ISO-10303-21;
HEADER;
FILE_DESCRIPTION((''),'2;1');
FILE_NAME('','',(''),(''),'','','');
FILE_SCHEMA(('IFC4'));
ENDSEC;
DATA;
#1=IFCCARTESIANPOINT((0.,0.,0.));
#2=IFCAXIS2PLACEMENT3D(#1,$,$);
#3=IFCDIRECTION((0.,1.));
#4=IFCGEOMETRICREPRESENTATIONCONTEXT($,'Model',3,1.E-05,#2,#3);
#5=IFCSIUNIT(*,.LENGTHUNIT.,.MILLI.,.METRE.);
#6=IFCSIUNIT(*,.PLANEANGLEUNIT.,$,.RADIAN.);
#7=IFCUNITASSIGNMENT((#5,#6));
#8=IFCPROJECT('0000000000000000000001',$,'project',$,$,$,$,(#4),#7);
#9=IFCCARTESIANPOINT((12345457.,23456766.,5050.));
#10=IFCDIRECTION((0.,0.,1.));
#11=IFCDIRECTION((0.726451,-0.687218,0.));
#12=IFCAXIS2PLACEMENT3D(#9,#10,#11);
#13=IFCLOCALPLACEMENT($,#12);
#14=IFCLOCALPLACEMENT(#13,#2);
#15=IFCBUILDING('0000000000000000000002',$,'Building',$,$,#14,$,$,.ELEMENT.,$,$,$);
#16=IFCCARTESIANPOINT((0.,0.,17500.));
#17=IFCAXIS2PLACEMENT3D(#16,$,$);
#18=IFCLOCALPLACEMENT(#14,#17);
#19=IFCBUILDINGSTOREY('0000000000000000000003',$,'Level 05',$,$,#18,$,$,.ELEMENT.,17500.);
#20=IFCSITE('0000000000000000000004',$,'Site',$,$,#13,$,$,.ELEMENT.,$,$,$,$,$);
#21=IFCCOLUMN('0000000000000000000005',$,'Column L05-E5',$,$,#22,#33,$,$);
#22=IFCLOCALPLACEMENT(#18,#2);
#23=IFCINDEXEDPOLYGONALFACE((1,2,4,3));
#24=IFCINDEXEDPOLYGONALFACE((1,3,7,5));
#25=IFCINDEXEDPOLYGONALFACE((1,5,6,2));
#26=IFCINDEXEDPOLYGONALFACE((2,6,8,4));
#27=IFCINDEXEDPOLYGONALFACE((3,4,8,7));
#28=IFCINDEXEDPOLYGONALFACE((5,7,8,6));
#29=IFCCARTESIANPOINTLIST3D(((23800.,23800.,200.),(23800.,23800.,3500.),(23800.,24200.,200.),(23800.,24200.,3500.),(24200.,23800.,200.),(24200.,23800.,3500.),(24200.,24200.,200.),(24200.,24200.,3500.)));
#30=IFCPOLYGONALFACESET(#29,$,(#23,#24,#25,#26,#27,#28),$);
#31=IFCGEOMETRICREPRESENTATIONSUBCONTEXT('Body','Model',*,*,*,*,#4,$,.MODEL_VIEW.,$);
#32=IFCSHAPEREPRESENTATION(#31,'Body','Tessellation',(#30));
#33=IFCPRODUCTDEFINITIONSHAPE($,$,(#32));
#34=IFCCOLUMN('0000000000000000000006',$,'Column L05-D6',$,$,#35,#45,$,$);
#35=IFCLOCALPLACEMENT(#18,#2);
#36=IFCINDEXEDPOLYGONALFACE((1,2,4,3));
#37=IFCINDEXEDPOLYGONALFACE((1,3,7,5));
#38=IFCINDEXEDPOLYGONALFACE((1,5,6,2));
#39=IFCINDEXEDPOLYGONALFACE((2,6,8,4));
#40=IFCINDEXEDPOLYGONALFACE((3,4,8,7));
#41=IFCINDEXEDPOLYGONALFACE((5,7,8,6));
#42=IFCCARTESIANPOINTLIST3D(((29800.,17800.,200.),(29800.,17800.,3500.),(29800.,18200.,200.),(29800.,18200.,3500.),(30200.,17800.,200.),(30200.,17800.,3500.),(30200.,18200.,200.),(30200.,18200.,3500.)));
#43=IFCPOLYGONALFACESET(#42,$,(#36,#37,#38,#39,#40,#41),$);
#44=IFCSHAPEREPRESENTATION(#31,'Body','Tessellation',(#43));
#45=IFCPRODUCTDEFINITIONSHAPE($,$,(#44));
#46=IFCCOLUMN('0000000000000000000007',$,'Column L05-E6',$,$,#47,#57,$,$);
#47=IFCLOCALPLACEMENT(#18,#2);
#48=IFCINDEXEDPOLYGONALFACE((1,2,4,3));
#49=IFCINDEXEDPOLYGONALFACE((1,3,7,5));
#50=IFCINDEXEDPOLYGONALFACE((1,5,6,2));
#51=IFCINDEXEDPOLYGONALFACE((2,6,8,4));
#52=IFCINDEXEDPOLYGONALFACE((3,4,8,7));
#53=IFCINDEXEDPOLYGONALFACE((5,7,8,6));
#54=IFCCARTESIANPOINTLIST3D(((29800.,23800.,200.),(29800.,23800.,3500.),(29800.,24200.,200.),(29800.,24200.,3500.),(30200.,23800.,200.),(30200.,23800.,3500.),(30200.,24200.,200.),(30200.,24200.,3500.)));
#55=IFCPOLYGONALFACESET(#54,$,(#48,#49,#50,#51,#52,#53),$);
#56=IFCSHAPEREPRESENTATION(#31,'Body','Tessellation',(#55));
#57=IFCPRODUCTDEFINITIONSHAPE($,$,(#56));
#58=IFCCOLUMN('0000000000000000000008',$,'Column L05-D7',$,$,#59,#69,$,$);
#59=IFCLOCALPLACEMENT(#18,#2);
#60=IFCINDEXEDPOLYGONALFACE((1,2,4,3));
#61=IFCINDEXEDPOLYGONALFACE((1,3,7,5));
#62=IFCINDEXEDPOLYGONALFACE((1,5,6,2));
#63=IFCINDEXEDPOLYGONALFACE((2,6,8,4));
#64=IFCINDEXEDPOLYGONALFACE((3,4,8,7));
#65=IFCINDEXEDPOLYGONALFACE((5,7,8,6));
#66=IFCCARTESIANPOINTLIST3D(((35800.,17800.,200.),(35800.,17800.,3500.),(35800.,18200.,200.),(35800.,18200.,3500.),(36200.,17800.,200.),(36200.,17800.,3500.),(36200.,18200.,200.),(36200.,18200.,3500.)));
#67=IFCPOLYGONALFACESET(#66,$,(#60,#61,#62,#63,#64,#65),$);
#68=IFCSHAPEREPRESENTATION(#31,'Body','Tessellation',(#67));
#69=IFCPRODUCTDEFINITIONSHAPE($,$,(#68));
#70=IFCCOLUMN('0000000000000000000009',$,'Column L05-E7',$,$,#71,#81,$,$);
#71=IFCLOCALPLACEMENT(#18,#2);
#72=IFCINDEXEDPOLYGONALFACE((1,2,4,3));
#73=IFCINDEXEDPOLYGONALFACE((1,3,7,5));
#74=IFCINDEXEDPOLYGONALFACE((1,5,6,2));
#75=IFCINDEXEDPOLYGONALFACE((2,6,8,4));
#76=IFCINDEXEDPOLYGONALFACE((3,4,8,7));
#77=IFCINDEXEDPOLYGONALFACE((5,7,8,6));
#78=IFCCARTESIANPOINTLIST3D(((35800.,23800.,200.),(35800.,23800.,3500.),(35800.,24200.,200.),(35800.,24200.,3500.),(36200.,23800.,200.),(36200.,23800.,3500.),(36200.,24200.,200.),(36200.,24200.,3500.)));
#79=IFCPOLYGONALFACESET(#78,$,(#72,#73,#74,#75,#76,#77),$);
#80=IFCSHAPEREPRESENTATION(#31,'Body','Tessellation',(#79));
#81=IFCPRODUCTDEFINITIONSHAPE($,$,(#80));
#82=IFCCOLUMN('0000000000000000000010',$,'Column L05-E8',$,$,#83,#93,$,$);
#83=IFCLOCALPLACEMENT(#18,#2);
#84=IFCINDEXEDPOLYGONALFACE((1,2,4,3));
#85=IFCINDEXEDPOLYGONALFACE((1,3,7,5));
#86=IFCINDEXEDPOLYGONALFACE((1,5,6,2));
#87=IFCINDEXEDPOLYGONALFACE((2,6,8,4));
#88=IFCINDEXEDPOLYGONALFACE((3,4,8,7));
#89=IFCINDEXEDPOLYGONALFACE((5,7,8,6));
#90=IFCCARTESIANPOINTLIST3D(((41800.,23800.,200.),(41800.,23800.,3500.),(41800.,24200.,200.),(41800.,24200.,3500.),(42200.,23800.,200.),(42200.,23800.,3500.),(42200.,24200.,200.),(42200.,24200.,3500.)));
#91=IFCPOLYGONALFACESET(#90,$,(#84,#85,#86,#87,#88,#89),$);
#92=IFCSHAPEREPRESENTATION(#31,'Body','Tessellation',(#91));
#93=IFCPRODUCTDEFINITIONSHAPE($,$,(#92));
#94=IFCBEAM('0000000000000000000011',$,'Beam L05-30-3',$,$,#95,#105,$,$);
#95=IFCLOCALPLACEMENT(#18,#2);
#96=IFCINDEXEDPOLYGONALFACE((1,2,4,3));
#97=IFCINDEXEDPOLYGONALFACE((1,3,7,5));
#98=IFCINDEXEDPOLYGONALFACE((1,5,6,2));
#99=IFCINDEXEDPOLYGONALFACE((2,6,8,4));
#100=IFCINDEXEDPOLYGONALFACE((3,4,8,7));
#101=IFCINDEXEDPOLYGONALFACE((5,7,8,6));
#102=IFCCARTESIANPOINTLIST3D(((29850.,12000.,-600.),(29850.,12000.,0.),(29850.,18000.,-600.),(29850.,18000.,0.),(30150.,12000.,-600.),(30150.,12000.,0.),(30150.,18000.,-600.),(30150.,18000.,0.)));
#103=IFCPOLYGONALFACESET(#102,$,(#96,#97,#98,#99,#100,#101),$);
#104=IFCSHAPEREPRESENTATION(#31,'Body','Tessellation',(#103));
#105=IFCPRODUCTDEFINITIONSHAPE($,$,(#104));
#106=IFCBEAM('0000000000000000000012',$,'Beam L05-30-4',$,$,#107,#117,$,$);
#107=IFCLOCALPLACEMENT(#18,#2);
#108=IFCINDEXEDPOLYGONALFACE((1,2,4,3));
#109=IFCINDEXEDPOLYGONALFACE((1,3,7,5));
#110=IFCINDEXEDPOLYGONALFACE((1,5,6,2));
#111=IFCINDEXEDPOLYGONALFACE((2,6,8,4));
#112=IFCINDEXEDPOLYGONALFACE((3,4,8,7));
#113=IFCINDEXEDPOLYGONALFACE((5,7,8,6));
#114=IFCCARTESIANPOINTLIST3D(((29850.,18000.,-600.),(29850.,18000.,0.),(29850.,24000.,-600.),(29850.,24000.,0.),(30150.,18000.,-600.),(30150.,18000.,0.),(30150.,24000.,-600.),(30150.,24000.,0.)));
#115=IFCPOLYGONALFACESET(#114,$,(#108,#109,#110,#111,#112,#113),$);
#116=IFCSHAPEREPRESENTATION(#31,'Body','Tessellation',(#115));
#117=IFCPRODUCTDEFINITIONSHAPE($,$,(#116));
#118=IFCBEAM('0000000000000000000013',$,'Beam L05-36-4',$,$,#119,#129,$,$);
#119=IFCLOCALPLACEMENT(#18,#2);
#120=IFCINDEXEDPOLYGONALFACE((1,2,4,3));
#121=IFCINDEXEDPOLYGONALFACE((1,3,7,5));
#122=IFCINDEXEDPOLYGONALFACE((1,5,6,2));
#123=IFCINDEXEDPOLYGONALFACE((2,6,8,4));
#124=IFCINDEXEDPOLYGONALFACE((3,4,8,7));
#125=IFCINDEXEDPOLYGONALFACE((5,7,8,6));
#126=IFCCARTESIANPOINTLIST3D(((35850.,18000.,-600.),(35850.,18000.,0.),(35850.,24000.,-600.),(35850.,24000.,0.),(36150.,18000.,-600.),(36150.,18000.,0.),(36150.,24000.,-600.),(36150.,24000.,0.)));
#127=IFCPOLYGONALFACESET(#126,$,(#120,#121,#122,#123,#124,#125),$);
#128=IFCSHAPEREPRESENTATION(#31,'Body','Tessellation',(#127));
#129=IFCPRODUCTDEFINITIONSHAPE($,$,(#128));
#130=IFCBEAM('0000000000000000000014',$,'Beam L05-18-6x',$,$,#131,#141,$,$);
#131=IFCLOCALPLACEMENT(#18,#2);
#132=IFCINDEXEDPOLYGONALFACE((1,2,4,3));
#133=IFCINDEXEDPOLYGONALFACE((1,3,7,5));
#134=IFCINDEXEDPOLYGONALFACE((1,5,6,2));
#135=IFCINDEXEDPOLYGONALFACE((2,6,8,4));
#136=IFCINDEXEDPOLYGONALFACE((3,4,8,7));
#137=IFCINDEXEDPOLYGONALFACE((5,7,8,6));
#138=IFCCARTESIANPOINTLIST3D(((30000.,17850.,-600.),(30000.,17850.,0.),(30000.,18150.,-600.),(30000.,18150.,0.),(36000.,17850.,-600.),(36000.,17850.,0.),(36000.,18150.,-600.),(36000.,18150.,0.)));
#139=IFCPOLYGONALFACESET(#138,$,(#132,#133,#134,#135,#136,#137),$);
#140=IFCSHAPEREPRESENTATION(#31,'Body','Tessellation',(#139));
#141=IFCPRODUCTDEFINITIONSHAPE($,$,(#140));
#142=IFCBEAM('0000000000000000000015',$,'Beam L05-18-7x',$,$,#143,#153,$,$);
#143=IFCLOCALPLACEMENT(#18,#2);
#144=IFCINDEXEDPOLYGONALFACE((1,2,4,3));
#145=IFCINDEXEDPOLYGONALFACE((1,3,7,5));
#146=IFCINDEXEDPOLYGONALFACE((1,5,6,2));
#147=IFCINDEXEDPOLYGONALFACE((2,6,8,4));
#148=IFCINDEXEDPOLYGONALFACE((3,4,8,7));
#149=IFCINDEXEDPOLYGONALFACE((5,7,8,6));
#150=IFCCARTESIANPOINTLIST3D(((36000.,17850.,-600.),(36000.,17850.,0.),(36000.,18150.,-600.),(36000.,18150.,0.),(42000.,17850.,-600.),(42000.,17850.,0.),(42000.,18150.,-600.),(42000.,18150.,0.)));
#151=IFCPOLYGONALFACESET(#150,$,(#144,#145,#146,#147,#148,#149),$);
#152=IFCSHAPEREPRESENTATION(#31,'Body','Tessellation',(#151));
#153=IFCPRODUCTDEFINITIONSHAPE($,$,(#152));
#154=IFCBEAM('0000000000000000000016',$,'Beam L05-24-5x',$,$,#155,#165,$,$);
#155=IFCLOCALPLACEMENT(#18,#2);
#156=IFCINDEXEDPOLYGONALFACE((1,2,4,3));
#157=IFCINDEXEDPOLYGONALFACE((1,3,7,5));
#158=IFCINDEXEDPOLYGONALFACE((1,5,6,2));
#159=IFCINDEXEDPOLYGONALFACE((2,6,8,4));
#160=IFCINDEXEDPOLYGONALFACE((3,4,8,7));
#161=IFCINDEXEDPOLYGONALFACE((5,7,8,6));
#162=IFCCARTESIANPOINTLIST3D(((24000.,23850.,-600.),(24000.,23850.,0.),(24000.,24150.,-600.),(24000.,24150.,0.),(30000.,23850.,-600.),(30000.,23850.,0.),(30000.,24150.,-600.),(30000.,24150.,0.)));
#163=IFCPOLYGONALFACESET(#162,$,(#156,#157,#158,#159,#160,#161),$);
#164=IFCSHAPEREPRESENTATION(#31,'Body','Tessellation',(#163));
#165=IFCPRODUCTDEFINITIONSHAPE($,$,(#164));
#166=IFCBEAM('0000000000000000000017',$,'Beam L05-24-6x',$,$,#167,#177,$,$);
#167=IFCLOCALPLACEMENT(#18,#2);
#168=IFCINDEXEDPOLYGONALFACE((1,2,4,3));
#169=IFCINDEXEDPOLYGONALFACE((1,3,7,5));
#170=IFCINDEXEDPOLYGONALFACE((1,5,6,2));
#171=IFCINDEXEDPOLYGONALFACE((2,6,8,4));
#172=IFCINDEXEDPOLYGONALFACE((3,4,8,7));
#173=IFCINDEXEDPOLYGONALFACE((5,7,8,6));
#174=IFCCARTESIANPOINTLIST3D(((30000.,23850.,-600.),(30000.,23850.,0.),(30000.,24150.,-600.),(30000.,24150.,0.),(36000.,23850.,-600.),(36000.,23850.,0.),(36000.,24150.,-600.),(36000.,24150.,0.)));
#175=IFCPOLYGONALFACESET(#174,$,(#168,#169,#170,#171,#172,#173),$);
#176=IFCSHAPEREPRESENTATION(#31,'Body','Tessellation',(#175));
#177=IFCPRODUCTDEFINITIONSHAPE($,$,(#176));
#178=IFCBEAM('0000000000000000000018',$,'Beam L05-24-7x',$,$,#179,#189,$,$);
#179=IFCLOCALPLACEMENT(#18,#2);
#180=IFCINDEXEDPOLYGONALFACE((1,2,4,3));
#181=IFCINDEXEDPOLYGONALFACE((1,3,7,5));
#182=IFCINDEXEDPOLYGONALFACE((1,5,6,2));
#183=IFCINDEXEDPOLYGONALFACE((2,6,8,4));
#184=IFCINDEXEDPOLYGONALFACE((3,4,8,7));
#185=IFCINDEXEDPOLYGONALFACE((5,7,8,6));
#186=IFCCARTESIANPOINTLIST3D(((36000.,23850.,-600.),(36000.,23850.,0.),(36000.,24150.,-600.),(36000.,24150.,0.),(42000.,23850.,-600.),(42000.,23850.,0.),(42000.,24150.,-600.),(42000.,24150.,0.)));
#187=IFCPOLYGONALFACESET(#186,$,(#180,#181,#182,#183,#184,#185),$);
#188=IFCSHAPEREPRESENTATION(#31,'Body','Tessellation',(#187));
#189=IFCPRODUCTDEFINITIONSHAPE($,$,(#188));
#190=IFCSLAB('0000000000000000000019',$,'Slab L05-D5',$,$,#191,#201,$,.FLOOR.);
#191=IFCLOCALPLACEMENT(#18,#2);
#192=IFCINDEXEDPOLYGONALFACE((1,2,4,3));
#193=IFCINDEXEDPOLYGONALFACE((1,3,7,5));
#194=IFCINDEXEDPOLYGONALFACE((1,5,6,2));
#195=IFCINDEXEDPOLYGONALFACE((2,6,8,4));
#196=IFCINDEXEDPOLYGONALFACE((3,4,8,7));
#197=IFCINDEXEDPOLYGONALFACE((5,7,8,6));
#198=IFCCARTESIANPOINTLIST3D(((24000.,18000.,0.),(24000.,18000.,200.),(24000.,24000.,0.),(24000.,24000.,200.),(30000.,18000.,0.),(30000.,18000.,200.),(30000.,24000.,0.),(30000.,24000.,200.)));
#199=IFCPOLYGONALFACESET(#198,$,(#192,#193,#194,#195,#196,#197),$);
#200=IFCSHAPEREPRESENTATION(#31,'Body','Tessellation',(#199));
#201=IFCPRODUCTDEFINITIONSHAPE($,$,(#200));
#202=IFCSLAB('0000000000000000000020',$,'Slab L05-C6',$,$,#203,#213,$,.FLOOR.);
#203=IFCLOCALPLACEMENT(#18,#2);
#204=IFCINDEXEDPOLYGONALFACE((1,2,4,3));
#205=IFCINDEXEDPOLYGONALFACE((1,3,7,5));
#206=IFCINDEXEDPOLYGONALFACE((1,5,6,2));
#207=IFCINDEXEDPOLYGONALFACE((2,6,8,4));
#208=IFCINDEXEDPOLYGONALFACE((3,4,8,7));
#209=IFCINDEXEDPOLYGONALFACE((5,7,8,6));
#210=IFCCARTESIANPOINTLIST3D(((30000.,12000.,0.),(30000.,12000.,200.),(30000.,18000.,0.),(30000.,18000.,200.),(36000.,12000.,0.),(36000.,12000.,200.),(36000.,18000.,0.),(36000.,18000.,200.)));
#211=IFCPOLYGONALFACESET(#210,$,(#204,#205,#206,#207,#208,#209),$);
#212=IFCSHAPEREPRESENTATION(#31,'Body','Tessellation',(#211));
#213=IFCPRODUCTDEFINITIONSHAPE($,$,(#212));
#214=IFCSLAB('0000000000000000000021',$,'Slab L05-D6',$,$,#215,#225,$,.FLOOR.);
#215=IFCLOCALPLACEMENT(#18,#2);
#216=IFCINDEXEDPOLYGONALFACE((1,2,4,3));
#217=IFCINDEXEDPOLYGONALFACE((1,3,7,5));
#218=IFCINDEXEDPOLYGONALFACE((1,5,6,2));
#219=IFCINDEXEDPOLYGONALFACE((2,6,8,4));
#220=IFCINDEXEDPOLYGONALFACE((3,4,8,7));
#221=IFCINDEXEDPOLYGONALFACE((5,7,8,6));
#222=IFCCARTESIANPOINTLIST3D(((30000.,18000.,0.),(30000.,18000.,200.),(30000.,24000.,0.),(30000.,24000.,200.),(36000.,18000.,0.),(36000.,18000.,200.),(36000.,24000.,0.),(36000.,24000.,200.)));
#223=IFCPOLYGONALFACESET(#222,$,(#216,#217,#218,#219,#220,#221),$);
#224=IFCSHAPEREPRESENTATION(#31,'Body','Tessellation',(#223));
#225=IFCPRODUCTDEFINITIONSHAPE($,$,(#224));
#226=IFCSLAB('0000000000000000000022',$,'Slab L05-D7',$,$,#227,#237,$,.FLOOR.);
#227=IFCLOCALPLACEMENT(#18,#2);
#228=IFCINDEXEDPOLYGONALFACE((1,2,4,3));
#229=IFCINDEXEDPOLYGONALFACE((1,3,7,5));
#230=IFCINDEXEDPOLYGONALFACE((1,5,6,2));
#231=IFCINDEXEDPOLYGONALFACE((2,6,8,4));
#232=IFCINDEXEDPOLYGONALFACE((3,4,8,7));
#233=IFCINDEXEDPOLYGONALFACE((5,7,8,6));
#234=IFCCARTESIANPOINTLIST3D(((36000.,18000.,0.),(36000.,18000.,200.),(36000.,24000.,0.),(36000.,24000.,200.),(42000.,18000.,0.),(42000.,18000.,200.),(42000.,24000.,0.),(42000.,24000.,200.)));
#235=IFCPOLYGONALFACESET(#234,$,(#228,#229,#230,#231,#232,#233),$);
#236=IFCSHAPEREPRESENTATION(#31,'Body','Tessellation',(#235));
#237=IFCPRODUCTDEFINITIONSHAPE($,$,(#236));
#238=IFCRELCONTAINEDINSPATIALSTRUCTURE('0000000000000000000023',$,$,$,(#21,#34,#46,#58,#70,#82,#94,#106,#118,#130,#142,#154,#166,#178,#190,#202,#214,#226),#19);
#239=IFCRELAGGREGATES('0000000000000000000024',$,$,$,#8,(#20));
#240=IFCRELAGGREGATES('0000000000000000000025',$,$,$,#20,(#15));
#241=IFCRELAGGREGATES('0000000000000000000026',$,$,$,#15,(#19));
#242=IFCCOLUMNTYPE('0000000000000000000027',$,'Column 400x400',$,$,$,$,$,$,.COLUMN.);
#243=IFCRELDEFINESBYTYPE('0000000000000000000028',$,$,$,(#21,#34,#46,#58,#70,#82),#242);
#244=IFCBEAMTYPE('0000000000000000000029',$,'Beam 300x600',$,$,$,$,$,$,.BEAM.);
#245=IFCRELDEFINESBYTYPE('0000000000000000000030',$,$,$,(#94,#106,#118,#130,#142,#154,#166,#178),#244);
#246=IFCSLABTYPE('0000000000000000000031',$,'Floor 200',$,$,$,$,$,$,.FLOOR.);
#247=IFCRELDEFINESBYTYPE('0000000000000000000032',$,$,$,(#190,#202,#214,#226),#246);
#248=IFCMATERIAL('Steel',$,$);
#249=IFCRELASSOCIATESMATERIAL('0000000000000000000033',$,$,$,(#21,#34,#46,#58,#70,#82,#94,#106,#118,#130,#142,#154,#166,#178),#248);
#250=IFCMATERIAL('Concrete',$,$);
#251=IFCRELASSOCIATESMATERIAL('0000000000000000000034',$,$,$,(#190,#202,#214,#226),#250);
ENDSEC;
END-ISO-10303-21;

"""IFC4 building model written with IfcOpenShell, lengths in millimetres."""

from ifc_helpers import new_model, si_unit, direction, frame, origin, place, context, subcontext, project, spatial, rectangle, extrude, material, type_object, element, save


model = new_model("IFC4")

# Units and contexts
model_context = context("Model", 3, precision=1e-05, world=origin(), true_north=direction((0.0, 1.0)))
body_context = subcontext(model_context, "Body", "Model", "MODEL_VIEW")
ifc_project = project(units=[si_unit("LENGTHUNIT", "METRE", prefix="MILLI"), si_unit("PLANEANGLEUNIT", "RADIAN")], contexts=[model_context])

# Site, building, storey
site_placement = place(None, frame((12345457.0, 23456766.0, 5050.0), z_axis=(0.0, 0.0, 1.0), x_axis=(0.726451, -0.687218, 0.0)))
site = spatial("IfcSite", under=ifc_project, at=site_placement, Name="Site", CompositionType="ELEMENT")
building_placement = place(site_placement, origin())
building = spatial("IfcBuilding", under=site, at=building_placement, Name="Building", CompositionType="ELEMENT")
storey_placement = place(building_placement, frame((0.0, 0.0, 17500.0)))
storey = spatial("IfcBuildingStorey", under=building, at=storey_placement, Name="Level 05", CompositionType="ELEMENT", Elevation=17500.0)

# Columns
ifc_material_1 = material(Name="Steel")
column_type = type_object("IfcColumnType", Name="Column 400x400", PredefinedType="COLUMN")
for number, where, name in (
    (1, (23800.0, 23800.0, 200.0), "Column L05-E5"),
    (2, (29800.0, 17800.0, 200.0), "Column L05-D6"),
    (3, (29800.0, 23800.0, 200.0), "Column L05-E6"),
    (4, (35800.0, 17800.0, 200.0), "Column L05-D7"),
    (5, (35800.0, 23800.0, 200.0), "Column L05-E7"),
    (6, (41800.0, 23800.0, 200.0), "Column L05-E8"),
):
    element("IfcColumn", number, at=place(storey_placement, frame(where)), inside=storey, type_object=column_type, material=ifc_material_1, Name=name, context=body_context, shape_type="SweptSolid", body=[
        extrude(rectangle(XDim=400.0, YDim=400.0), frame((200.0, 200.0, 0.0)), (0.0, 0.0, 1.0), 3300.0),
    ])

# Beams
beam_type = type_object("IfcBeamType", Name="Beam 300x600", PredefinedType="BEAM")
for number, where, name in (
    (7, (29850.0, 12000.0, -600.0), "Beam L05-30-3"),
    (8, (29850.0, 18000.0, -600.0), "Beam L05-30-4"),
    (9, (35850.0, 18000.0, -600.0), "Beam L05-36-4"),
):
    element("IfcBeam", number, at=place(storey_placement, frame(where)), inside=storey, type_object=beam_type, material=ifc_material_1, Name=name, context=body_context, shape_type="SweptSolid", body=[
        extrude(rectangle(XDim=300.0, YDim=6000.0), frame((150.0, 3000.0, 0.0)), (0.0, 0.0, 1.0), 600.0),
    ])
for number, where, name in (
    (10, (30000.0, 17850.0, -600.0), "Beam L05-18-6x"),
    (11, (36000.0, 17850.0, -600.0), "Beam L05-18-7x"),
    (12, (24000.0, 23850.0, -600.0), "Beam L05-24-5x"),
    (13, (30000.0, 23850.0, -600.0), "Beam L05-24-6x"),
    (14, (36000.0, 23850.0, -600.0), "Beam L05-24-7x"),
):
    element("IfcBeam", number, at=place(storey_placement, frame(where)), inside=storey, type_object=beam_type, material=ifc_material_1, Name=name, context=body_context, shape_type="SweptSolid", body=[
        extrude(rectangle(XDim=6000.0, YDim=300.0), frame((3000.0, 150.0, 0.0)), (0.0, 0.0, 1.0), 600.0),
    ])

# Slabs
ifc_material_2 = material(Name="Concrete")
slab_type = type_object("IfcSlabType", Name="Floor 200", PredefinedType="FLOOR")
for number, where, name in (
    (15, (24000.0, 18000.0, 0.0), "Slab L05-D5"),
    (16, (30000.0, 12000.0, 0.0), "Slab L05-C6"),
    (17, (30000.0, 18000.0, 0.0), "Slab L05-D6"),
    (18, (36000.0, 18000.0, 0.0), "Slab L05-D7"),
):
    element("IfcSlab", number, at=place(storey_placement, frame(where)), inside=storey, type_object=slab_type, material=ifc_material_2, Name=name, PredefinedType="FLOOR", context=body_context, shape_type="SweptSolid", body=[
        extrude(rectangle(XDim=6000.0, YDim=6000.0), frame((3000.0, 3000.0, 0.0)), (0.0, 0.0, 1.0), 200.0),
    ])

save(model, "model.ifc")
